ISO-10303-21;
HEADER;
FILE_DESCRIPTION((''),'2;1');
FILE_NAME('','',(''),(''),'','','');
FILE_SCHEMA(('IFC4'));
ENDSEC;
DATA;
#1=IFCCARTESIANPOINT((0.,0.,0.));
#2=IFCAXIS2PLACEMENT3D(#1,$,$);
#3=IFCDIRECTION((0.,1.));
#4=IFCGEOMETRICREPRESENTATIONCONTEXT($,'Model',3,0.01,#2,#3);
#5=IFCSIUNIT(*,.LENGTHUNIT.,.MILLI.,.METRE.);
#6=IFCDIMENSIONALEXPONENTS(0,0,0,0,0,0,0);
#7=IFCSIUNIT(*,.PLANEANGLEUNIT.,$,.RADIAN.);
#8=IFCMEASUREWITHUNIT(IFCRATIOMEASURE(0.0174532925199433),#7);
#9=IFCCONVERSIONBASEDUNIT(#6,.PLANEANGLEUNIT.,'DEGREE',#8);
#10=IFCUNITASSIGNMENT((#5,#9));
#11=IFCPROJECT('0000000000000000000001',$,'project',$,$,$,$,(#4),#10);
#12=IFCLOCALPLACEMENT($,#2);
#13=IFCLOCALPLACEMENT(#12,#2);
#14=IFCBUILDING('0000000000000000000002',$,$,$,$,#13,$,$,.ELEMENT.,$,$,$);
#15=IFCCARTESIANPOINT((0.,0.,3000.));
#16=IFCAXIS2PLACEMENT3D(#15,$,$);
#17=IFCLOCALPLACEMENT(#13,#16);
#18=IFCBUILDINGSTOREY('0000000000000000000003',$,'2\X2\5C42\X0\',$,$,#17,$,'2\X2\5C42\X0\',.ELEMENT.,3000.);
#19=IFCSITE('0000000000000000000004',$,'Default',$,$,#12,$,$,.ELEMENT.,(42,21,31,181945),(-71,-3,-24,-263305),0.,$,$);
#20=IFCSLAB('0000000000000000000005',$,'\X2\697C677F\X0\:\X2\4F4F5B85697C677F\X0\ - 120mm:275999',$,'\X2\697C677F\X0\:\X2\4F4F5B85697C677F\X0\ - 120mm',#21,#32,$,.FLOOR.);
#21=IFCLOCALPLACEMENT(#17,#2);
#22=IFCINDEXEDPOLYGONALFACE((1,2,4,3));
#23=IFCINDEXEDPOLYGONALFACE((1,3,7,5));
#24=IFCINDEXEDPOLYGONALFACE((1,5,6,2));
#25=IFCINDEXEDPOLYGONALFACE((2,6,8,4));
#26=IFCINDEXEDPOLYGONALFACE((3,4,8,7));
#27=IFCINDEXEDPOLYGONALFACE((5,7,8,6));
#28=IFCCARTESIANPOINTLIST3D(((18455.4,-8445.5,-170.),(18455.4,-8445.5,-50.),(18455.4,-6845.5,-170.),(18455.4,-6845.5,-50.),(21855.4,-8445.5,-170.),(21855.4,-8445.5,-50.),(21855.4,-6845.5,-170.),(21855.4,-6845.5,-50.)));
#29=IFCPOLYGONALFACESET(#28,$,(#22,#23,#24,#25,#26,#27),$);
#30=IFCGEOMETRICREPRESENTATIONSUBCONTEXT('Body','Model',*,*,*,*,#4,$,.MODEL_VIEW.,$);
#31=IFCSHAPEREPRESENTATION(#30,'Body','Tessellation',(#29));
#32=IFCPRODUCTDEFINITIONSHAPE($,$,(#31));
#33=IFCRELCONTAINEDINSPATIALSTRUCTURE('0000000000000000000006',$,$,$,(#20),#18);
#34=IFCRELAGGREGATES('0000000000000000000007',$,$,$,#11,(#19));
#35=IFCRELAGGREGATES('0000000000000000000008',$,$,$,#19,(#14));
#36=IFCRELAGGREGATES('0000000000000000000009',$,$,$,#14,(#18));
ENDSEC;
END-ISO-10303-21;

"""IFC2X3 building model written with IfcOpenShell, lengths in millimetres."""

from ifc_helpers import new_model, entity, si_unit, converted_unit, direction, frame, frame_2d, origin, place, context, subcontext, project, spatial, rectangle, extrude, element, save


model = new_model("IFC2X3")

# Units and contexts
model_context = context("Model", 3, precision=0.01, world=origin(), true_north=direction((0.0, 1.0)))
body_context = subcontext(model_context, "Body", "Model", "MODEL_VIEW")
ifc_project = project(units=[si_unit("LENGTHUNIT", "METRE", prefix="MILLI"), converted_unit("PLANEANGLEUNIT", "DEGREE", entity("IfcRatioMeasure", 0.0174532925199433), si_unit("PLANEANGLEUNIT", "RADIAN"), dimensions=[0, 0, 0, 0, 0, 0, 0])], contexts=[model_context])

# Site, building, storey
site_placement = place(None, origin())
site = spatial("IfcSite", under=ifc_project, at=site_placement, Name="Default", CompositionType="ELEMENT", RefLatitude=(42, 21, 31, 181945), RefLongitude=(-71, -3, -24, -263305), RefElevation=0.0)
building_placement = place(site_placement, origin())
building = spatial("IfcBuilding", under=site, at=building_placement, CompositionType="ELEMENT")
storey_placement = place(building_placement, frame((0.0, 0.0, 3000.0)))
storey = spatial("IfcBuildingStorey", under=building, at=storey_placement, Name="2层", LongName="2层", CompositionType="ELEMENT", Elevation=3000.0)

# Slab
slab_1_placement = place(storey_placement, origin())
element("IfcSlab", 1, at=slab_1_placement, inside=storey, Name="楼板:住宅楼板 - 120mm:275999", ObjectType="楼板:住宅楼板 - 120mm", PredefinedType="FLOOR", context=body_context, shape_type="SweptSolid", body=[
    extrude(rectangle(XDim=1600.0, YDim=3400.0, at=frame_2d((0.0, 0.0), x_axis=(1.0, 0.0))), frame((20155.4, -7645.5, -50.0), z_axis=(0.0, 0.0, -1.0), x_axis=(0.0, 1.0, 0.0)), (0.0, 0.0, 1.0), 120.0),
])

save(model, "model.ifc")
